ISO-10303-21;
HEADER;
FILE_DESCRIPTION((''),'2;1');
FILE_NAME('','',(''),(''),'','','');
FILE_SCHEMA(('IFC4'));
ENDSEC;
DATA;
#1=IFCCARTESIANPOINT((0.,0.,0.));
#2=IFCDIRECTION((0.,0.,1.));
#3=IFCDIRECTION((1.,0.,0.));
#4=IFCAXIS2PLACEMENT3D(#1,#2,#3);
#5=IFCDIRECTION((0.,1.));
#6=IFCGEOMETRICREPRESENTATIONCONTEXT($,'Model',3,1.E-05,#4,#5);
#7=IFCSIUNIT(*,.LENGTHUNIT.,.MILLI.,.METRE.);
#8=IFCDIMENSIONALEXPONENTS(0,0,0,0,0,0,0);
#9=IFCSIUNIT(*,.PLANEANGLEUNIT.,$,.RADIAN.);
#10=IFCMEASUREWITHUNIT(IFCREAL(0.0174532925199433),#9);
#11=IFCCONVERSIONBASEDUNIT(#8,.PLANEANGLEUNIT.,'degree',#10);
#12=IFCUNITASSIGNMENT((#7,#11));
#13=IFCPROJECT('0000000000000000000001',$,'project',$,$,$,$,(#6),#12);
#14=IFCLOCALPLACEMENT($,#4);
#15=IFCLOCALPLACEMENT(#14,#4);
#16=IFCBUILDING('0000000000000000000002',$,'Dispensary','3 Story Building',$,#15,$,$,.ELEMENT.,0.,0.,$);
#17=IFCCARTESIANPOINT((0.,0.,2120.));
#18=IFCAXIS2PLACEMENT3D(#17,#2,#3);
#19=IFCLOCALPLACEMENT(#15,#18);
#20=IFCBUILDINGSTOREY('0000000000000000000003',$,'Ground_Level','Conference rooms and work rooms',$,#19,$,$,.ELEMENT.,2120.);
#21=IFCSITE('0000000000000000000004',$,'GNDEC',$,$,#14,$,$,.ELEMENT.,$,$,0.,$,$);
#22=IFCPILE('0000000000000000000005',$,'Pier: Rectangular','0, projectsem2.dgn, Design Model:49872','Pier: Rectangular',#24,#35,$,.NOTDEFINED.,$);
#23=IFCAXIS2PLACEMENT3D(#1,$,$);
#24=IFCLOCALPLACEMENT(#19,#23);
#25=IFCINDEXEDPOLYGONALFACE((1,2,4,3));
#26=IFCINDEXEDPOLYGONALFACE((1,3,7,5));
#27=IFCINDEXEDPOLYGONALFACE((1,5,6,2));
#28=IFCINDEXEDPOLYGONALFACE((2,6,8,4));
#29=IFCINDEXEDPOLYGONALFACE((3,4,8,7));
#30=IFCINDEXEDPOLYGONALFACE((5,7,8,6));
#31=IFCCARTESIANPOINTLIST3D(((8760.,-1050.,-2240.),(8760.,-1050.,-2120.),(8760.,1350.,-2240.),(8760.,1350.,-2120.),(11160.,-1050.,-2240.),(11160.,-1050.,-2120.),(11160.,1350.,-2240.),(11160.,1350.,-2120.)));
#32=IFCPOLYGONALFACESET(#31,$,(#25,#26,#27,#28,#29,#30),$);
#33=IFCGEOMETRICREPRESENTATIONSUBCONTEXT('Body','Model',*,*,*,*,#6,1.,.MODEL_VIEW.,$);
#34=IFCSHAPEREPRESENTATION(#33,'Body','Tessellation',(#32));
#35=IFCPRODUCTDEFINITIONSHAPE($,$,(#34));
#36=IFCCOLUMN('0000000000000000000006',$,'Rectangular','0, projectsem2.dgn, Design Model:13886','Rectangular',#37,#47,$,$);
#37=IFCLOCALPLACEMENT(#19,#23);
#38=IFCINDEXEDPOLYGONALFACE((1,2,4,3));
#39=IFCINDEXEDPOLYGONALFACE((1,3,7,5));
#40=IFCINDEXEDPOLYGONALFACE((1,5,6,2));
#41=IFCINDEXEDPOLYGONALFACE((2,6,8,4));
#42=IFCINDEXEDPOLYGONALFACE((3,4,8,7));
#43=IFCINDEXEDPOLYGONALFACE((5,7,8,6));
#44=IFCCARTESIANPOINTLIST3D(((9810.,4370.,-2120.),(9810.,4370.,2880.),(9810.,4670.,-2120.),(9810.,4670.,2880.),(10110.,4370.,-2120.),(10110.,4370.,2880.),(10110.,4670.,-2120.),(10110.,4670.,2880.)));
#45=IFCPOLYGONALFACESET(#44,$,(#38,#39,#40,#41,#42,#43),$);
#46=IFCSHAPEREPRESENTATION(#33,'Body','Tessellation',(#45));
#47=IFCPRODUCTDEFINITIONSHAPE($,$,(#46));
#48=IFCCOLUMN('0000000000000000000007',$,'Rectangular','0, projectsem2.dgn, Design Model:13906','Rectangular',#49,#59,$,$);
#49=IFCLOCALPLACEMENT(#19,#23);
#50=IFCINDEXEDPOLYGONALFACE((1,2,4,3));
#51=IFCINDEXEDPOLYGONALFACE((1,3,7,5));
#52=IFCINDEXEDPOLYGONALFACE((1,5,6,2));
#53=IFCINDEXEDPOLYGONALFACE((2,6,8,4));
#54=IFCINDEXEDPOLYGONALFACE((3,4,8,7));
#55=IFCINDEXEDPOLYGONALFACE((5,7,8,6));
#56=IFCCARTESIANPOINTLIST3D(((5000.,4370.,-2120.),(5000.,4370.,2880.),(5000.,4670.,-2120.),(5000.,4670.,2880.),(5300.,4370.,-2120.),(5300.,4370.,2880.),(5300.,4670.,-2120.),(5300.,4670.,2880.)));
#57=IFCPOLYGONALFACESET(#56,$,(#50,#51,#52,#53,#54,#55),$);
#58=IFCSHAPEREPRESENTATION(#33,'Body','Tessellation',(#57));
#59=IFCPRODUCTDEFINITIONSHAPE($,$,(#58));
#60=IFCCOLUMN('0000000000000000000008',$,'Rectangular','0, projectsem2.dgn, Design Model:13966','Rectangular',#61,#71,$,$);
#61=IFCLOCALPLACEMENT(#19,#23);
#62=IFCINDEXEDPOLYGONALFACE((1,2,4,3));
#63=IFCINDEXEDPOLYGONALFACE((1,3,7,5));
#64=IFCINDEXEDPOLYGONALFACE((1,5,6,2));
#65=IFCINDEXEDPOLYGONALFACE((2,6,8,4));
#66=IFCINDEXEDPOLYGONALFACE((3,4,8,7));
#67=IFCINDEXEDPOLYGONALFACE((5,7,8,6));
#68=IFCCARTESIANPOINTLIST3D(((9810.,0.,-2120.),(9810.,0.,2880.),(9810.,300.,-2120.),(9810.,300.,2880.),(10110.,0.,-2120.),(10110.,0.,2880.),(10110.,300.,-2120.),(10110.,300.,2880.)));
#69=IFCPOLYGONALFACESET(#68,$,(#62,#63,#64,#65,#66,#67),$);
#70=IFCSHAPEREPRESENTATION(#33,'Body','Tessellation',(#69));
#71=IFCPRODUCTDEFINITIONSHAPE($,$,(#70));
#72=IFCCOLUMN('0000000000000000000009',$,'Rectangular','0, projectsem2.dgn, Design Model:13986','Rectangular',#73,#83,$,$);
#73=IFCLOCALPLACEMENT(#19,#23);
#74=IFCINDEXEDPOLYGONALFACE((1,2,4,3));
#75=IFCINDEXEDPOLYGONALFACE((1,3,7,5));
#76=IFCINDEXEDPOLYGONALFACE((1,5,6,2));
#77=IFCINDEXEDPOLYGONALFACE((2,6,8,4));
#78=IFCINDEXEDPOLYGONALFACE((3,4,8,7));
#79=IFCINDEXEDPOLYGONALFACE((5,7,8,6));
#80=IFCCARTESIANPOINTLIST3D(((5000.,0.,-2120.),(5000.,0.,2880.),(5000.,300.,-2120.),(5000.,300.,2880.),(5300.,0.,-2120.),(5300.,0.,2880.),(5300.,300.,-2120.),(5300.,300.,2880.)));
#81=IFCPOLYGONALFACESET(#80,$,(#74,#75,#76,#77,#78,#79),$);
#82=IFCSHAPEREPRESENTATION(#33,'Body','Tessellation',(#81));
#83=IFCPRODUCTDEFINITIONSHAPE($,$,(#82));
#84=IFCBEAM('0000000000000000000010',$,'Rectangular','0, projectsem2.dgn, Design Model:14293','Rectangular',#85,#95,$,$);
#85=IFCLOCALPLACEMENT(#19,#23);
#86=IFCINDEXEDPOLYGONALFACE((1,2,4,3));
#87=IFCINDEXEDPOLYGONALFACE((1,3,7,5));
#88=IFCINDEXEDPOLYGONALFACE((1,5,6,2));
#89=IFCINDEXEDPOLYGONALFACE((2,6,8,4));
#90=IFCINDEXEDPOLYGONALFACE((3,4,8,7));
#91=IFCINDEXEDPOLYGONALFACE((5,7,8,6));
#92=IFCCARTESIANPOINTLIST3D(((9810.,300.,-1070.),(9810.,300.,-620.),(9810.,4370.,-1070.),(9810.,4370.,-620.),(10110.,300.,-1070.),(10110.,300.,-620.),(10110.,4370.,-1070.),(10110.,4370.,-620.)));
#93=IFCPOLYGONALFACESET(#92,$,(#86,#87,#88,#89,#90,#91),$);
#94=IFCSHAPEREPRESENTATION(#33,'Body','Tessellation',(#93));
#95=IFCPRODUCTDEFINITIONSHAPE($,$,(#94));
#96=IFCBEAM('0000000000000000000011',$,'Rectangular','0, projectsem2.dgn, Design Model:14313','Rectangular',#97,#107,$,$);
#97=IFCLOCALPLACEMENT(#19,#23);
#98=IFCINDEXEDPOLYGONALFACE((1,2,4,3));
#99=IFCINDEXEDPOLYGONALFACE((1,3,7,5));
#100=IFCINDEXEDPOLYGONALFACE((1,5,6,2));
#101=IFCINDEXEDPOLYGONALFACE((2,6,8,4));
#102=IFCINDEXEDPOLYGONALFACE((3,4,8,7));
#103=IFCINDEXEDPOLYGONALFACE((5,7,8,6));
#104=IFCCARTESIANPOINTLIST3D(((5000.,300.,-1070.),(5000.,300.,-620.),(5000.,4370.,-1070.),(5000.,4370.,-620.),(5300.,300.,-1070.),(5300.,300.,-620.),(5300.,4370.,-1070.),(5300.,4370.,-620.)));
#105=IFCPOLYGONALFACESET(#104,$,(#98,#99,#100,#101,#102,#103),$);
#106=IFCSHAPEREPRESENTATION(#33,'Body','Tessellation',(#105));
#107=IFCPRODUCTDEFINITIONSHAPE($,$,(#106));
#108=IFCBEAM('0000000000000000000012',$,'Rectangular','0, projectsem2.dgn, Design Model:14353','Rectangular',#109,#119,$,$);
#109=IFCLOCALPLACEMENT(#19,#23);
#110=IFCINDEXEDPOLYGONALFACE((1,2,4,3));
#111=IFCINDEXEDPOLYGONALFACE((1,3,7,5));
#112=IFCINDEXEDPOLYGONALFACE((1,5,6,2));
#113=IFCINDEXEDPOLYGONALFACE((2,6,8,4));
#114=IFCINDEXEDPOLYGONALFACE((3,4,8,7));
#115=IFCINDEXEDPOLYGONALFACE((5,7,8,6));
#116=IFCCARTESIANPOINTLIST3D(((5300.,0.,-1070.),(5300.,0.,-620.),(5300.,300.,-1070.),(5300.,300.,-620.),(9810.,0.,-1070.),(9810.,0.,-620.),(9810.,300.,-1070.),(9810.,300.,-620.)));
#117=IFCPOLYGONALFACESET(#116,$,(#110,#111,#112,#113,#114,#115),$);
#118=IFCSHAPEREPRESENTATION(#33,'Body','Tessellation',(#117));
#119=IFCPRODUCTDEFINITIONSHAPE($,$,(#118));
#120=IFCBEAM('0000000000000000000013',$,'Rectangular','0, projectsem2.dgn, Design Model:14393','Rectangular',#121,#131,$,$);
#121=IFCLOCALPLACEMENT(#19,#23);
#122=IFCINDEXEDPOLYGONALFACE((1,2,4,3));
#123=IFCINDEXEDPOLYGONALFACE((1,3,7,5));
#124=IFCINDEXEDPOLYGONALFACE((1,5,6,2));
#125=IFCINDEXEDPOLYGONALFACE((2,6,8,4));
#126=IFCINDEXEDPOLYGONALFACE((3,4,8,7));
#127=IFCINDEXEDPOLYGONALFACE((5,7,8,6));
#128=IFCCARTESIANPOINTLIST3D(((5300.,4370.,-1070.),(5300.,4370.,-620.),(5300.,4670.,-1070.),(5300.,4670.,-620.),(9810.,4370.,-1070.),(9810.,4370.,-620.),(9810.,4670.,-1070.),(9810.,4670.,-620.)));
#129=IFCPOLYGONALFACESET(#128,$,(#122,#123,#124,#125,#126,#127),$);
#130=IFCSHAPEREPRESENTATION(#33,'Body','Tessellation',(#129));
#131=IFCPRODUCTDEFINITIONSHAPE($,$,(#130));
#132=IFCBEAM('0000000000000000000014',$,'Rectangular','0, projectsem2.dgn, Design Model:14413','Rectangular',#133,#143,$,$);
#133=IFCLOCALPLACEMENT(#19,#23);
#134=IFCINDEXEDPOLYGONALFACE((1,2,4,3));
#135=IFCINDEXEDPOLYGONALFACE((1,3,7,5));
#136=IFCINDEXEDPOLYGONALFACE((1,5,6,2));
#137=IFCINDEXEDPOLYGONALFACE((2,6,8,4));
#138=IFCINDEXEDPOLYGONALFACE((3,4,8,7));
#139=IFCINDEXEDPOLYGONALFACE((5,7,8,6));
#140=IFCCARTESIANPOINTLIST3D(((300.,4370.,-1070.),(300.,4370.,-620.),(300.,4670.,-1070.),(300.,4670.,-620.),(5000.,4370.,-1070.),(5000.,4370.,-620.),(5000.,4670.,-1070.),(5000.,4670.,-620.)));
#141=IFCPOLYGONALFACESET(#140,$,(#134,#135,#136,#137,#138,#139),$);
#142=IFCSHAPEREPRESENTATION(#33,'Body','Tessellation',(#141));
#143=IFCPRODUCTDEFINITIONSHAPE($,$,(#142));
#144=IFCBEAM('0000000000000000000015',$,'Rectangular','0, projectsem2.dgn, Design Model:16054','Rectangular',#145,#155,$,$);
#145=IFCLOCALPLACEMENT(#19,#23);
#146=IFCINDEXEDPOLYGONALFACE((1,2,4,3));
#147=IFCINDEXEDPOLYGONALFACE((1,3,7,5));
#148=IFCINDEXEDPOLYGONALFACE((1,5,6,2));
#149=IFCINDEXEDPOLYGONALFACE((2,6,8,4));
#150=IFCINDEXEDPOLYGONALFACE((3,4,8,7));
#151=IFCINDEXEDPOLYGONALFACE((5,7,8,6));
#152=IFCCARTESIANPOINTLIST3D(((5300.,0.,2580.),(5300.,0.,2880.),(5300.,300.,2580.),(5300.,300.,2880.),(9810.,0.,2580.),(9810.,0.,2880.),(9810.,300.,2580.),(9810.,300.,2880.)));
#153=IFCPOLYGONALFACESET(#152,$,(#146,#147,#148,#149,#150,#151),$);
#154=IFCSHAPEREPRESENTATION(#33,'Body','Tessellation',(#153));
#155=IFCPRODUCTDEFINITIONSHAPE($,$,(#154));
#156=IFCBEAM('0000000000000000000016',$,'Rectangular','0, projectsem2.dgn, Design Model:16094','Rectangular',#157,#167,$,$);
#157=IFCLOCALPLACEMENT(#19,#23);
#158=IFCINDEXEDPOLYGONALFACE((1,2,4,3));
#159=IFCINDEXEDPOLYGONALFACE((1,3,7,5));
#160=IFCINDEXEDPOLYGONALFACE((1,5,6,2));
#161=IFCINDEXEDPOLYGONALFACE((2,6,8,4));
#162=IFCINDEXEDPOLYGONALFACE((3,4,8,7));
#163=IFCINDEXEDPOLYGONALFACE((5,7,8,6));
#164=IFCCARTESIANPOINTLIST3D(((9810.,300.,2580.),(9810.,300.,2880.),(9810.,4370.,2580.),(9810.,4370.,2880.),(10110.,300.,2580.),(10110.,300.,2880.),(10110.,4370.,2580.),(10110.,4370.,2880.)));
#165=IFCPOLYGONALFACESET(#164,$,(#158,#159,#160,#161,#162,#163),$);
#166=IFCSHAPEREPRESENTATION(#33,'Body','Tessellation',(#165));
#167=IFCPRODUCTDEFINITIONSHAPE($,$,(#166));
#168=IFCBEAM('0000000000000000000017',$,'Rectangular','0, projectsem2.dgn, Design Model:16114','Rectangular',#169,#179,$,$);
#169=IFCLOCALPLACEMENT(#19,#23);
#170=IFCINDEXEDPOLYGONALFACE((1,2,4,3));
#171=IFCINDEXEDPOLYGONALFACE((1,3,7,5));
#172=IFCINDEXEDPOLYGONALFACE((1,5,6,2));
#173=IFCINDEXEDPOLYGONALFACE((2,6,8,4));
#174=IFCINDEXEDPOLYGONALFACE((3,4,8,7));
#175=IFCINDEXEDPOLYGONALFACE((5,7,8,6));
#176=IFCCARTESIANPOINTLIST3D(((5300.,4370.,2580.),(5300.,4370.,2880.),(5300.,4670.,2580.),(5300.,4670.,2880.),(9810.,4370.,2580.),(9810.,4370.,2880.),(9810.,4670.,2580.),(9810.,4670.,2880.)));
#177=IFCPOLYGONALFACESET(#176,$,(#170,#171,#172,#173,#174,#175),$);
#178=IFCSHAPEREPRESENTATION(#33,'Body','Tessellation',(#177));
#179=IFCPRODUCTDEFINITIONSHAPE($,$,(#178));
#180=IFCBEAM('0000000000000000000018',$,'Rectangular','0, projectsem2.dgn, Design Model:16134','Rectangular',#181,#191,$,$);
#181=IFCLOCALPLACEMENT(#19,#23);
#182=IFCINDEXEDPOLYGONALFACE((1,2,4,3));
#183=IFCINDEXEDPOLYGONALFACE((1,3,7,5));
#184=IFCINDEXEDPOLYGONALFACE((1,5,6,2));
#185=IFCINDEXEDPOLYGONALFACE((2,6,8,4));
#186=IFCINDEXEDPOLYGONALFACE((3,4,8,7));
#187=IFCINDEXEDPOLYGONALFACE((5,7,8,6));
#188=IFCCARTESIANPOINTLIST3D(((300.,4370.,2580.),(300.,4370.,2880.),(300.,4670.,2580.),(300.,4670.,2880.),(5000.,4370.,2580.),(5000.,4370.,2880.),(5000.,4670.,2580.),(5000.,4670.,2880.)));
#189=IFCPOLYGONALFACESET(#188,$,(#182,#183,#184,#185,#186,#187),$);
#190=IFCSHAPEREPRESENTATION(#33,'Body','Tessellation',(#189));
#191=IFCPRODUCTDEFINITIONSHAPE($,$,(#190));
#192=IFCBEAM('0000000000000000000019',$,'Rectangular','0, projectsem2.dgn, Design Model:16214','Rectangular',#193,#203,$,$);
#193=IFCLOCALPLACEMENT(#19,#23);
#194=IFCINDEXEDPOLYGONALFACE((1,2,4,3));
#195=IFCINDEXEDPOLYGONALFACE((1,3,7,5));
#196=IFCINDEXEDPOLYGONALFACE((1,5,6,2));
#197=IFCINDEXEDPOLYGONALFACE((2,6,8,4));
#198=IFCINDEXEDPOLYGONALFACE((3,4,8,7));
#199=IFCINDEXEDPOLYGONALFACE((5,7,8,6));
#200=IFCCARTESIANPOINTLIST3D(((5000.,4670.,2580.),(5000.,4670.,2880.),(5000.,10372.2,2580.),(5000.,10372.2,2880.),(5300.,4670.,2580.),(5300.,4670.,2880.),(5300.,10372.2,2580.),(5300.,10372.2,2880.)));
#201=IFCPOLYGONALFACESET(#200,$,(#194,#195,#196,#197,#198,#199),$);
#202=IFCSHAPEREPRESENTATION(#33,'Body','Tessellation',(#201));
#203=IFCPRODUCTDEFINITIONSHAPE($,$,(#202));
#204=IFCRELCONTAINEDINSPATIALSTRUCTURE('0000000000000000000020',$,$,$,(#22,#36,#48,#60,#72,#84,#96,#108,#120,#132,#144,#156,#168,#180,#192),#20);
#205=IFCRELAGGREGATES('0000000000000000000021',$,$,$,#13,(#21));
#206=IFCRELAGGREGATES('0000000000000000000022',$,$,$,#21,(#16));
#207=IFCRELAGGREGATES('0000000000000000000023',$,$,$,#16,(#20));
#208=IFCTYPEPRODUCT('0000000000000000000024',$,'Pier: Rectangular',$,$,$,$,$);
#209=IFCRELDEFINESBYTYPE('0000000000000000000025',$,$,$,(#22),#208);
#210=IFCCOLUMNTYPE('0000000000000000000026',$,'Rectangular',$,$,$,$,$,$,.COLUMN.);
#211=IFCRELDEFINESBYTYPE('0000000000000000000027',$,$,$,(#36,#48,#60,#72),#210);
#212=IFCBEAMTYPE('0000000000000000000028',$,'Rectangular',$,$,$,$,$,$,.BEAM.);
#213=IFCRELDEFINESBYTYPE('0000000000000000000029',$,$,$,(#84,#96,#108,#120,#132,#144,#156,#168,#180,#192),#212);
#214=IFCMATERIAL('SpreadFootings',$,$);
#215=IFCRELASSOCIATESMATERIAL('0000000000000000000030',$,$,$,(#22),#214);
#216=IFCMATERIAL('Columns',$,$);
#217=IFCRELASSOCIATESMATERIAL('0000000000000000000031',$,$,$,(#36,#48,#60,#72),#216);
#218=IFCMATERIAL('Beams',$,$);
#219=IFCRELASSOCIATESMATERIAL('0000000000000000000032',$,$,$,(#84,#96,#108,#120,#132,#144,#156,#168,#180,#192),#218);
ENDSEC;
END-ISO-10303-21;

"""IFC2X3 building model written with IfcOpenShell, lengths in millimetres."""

from ifc_helpers import new_model, entity, si_unit, converted_unit, direction, frame, frame_2d, origin_with_axes, place, context, subcontext, project, spatial, rectangle, extrude, material, type_object, element, save


model = new_model("IFC2X3")

# Units and contexts
model_context = context("Model", 3, precision=1e-05, world=origin_with_axes(), true_north=direction((0.0, 1.0)))
body_context = subcontext(model_context, "Body", "Model", "MODEL_VIEW", scale=1.0)
ifc_project = project(units=[si_unit("LENGTHUNIT", "METRE", prefix="MILLI"), converted_unit("PLANEANGLEUNIT", "degree", entity("IfcReal", 0.0174532925199433), si_unit("PLANEANGLEUNIT", "RADIAN"), dimensions=[0, 0, 0, 0, 0, 0, 0])], contexts=[model_context])

# Site, building, storey
site_placement = place(None, origin_with_axes())
site = spatial("IfcSite", under=ifc_project, at=site_placement, Name="GNDEC", CompositionType="ELEMENT", RefElevation=0.0)
building_placement = place(site_placement, origin_with_axes())
building = spatial("IfcBuilding", under=site, at=building_placement, Name="Dispensary", Description="3 Story Building", CompositionType="ELEMENT", ElevationOfRefHeight=0.0, ElevationOfTerrain=0.0)
storey_placement = place(building_placement, frame((0.0, 0.0, 2120.0), z_axis=(0.0, 0.0, 1.0), x_axis=(1.0, 0.0, 0.0)))
storey = spatial("IfcBuildingStorey", under=building, at=storey_placement, Name="Ground_Level", Description="Conference rooms and work rooms", CompositionType="ELEMENT", Elevation=2120.0)

# Pile
ifc_material_1 = material(Name="SpreadFootings")
type_product = type_object("IfcTypeProduct", Name="Pier: Rectangular")
pile_placement = place(storey_placement, frame((8760.0, 1350.0, -2240.0), z_axis=(0.0, 0.0, 1.0), x_axis=(0.0, -1.0, 0.0)))
element("IfcPile", 1, at=pile_placement, inside=storey, type_object=type_product, material=ifc_material_1, Name="Pier: Rectangular", Description="0, projectsem2.dgn, Design Model:49872", ObjectType="Pier: Rectangular", PredefinedType="NOTDEFINED", context=body_context, shape_type="SweptSolid", body=[
    extrude(rectangle(XDim=2400.0, YDim=2400.0, at=frame_2d((1200.0, 1200.0), x_axis=(0.0, 1.0))), origin_with_axes(), (0.0, 0.0, 1.0), 120.0),
])

# Columns
ifc_material_2 = material(Name="Columns")
column_type = type_object("IfcColumnType", Name="Rectangular", PredefinedType="COLUMN")
for number, where, z_axis, x_axis, name, description in (
    (2, (9810.0, 4670.0, -2120.0), (0.0, 0.0, 1.0), (0.0, -1.0, 0.0), "Rectangular", "0, projectsem2.dgn, Design Model:13886"),
    (3, (5000.0, 4670.0, -2120.0), (0.0, 0.0, 1.0), (0.0, -1.0, 0.0), "Rectangular", "0, projectsem2.dgn, Design Model:13906"),
    (4, (9810.0, 300.0, -2120.0), (0.0, 0.0, 1.0), (0.0, -1.0, 0.0), "Rectangular", "0, projectsem2.dgn, Design Model:13966"),
    (5, (5000.0, 300.0, -2120.0), (0.0, 0.0, 1.0), (0.0, -1.0, 0.0), "Rectangular", "0, projectsem2.dgn, Design Model:13986"),
):
    element("IfcColumn", number, at=place(storey_placement, frame(where, z_axis=z_axis, x_axis=x_axis)), inside=storey, type_object=column_type, material=ifc_material_2, Name=name, Description=description, ObjectType="Rectangular", context=body_context, shape_type="SweptSolid", body=[
        extrude(rectangle(XDim=300.0, YDim=300.0, at=frame_2d((150.0, 150.0), x_axis=(0.0, 1.0))), origin_with_axes(), (0.0, 0.0, 1.0), 5000.0),
    ])

# Beams
ifc_material_3 = material(Name="Beams")
beam_type = type_object("IfcBeamType", Name="Rectangular", PredefinedType="BEAM")
for number, where, z_axis, x_axis, name, description in (
    (6, (10110.0, 4370.0, -1070.0), (0.0, -1.0, 0.0), (0.0, 0.0, 1.0), "Rectangular", "0, projectsem2.dgn, Design Model:14293"),
    (7, (5300.0, 4370.0, -1070.0), (0.0, -1.0, 0.0), (0.0, 0.0, 1.0), "Rectangular", "0, projectsem2.dgn, Design Model:14313"),
):
    element("IfcBeam", number, at=place(storey_placement, frame(where, z_axis=z_axis, x_axis=x_axis)), inside=storey, type_object=beam_type, material=ifc_material_3, Name=name, Description=description, ObjectType="Rectangular", context=body_context, shape_type="SweptSolid", body=[
        extrude(rectangle(XDim=300.0, YDim=450.0, at=frame_2d((225.0, 150.0), x_axis=(0.0, 1.0))), origin_with_axes(), (0.0, 0.0, 1.0), 4070.0),
    ])
for number, where, z_axis, x_axis, name, description in (
    (8, (9810.0, 0.0, -1070.0), (-1.0, 0.0, 0.0), (0.0, 0.0, 1.0), "Rectangular", "0, projectsem2.dgn, Design Model:14353"),
    (9, (9810.0, 4370.0, -1070.0), (-1.0, 0.0, 0.0), (0.0, 0.0, 1.0), "Rectangular", "0, projectsem2.dgn, Design Model:14393"),
):
    element("IfcBeam", number, at=place(storey_placement, frame(where, z_axis=z_axis, x_axis=x_axis)), inside=storey, type_object=beam_type, material=ifc_material_3, Name=name, Description=description, ObjectType="Rectangular", context=body_context, shape_type="SweptSolid", body=[
        extrude(rectangle(XDim=300.0, YDim=450.0, at=frame_2d((225.0, 150.0), x_axis=(0.0, 1.0))), origin_with_axes(), (0.0, 0.0, 1.0), 4510.0),
    ])
beam_1_placement = place(storey_placement, frame((5000.0, 4370.0, -1070.0), z_axis=(-1.0, 0.0, 0.0), x_axis=(0.0, 0.0, 1.0)))
element("IfcBeam", 10, at=beam_1_placement, inside=storey, type_object=beam_type, material=ifc_material_3, Name="Rectangular", Description="0, projectsem2.dgn, Design Model:14413", ObjectType="Rectangular", context=body_context, shape_type="SweptSolid", body=[
    extrude(rectangle(XDim=300.0, YDim=450.0, at=frame_2d((225.0, 150.0), x_axis=(0.0, 1.0))), origin_with_axes(), (0.0, 0.0, 1.0), 4700.0),
])
beam_2_placement = place(storey_placement, frame((9810.0, 0.0, 2580.0), z_axis=(-1.0, 0.0, 0.0), x_axis=(0.0, 0.0, 1.0)))
element("IfcBeam", 11, at=beam_2_placement, inside=storey, type_object=beam_type, material=ifc_material_3, Name="Rectangular", Description="0, projectsem2.dgn, Design Model:16054", ObjectType="Rectangular", context=body_context, shape_type="SweptSolid", body=[
    extrude(rectangle(XDim=300.0, YDim=300.0, at=frame_2d((150.0, 150.0), x_axis=(0.0, 1.0))), origin_with_axes(), (0.0, 0.0, 1.0), 4510.0),
])
beam_3_placement = place(storey_placement, frame((9810.0, 300.0, 2580.0), z_axis=(0.0, 1.0, 0.0), x_axis=(0.0, 0.0, 1.0)))
element("IfcBeam", 12, at=beam_3_placement, inside=storey, type_object=beam_type, material=ifc_material_3, Name="Rectangular", Description="0, projectsem2.dgn, Design Model:16094", ObjectType="Rectangular", context=body_context, shape_type="SweptSolid", body=[
    extrude(rectangle(XDim=300.0, YDim=300.0, at=frame_2d((150.0, 150.0), x_axis=(0.0, 1.0))), origin_with_axes(), (0.0, 0.0, 1.0), 4070.0),
])
beam_4_placement = place(storey_placement, frame((9810.0, 4370.0, 2580.0), z_axis=(-1.0, 0.0, 0.0), x_axis=(0.0, 0.0, 1.0)))
element("IfcBeam", 13, at=beam_4_placement, inside=storey, type_object=beam_type, material=ifc_material_3, Name="Rectangular", Description="0, projectsem2.dgn, Design Model:16114", ObjectType="Rectangular", context=body_context, shape_type="SweptSolid", body=[
    extrude(rectangle(XDim=300.0, YDim=300.0, at=frame_2d((150.0, 150.0), x_axis=(0.0, 1.0))), origin_with_axes(), (0.0, 0.0, 1.0), 4510.0),
])
beam_5_placement = place(storey_placement, frame((5000.0, 4370.0, 2580.0), z_axis=(-1.0, 0.0, 0.0), x_axis=(0.0, 0.0, 1.0)))
element("IfcBeam", 14, at=beam_5_placement, inside=storey, type_object=beam_type, material=ifc_material_3, Name="Rectangular", Description="0, projectsem2.dgn, Design Model:16134", ObjectType="Rectangular", context=body_context, shape_type="SweptSolid", body=[
    extrude(rectangle(XDim=300.0, YDim=300.0, at=frame_2d((150.0, 150.0), x_axis=(0.0, 1.0))), origin_with_axes(), (0.0, 0.0, 1.0), 4700.0),
])
beam_6_placement = place(storey_placement, frame((5000.0, 4670.0, 2580.0), z_axis=(0.0, 1.0, 0.0), x_axis=(0.0, 0.0, 1.0)))
element("IfcBeam", 15, at=beam_6_placement, inside=storey, type_object=beam_type, material=ifc_material_3, Name="Rectangular", Description="0, projectsem2.dgn, Design Model:16214", ObjectType="Rectangular", context=body_context, shape_type="SweptSolid", body=[
    extrude(rectangle(XDim=300.0, YDim=300.0, at=frame_2d((150.0, 150.0), x_axis=(0.0, 1.0))), origin_with_axes(), (0.0, 0.0, 1.0), 5702.2),
])

save(model, "model.ifc")
